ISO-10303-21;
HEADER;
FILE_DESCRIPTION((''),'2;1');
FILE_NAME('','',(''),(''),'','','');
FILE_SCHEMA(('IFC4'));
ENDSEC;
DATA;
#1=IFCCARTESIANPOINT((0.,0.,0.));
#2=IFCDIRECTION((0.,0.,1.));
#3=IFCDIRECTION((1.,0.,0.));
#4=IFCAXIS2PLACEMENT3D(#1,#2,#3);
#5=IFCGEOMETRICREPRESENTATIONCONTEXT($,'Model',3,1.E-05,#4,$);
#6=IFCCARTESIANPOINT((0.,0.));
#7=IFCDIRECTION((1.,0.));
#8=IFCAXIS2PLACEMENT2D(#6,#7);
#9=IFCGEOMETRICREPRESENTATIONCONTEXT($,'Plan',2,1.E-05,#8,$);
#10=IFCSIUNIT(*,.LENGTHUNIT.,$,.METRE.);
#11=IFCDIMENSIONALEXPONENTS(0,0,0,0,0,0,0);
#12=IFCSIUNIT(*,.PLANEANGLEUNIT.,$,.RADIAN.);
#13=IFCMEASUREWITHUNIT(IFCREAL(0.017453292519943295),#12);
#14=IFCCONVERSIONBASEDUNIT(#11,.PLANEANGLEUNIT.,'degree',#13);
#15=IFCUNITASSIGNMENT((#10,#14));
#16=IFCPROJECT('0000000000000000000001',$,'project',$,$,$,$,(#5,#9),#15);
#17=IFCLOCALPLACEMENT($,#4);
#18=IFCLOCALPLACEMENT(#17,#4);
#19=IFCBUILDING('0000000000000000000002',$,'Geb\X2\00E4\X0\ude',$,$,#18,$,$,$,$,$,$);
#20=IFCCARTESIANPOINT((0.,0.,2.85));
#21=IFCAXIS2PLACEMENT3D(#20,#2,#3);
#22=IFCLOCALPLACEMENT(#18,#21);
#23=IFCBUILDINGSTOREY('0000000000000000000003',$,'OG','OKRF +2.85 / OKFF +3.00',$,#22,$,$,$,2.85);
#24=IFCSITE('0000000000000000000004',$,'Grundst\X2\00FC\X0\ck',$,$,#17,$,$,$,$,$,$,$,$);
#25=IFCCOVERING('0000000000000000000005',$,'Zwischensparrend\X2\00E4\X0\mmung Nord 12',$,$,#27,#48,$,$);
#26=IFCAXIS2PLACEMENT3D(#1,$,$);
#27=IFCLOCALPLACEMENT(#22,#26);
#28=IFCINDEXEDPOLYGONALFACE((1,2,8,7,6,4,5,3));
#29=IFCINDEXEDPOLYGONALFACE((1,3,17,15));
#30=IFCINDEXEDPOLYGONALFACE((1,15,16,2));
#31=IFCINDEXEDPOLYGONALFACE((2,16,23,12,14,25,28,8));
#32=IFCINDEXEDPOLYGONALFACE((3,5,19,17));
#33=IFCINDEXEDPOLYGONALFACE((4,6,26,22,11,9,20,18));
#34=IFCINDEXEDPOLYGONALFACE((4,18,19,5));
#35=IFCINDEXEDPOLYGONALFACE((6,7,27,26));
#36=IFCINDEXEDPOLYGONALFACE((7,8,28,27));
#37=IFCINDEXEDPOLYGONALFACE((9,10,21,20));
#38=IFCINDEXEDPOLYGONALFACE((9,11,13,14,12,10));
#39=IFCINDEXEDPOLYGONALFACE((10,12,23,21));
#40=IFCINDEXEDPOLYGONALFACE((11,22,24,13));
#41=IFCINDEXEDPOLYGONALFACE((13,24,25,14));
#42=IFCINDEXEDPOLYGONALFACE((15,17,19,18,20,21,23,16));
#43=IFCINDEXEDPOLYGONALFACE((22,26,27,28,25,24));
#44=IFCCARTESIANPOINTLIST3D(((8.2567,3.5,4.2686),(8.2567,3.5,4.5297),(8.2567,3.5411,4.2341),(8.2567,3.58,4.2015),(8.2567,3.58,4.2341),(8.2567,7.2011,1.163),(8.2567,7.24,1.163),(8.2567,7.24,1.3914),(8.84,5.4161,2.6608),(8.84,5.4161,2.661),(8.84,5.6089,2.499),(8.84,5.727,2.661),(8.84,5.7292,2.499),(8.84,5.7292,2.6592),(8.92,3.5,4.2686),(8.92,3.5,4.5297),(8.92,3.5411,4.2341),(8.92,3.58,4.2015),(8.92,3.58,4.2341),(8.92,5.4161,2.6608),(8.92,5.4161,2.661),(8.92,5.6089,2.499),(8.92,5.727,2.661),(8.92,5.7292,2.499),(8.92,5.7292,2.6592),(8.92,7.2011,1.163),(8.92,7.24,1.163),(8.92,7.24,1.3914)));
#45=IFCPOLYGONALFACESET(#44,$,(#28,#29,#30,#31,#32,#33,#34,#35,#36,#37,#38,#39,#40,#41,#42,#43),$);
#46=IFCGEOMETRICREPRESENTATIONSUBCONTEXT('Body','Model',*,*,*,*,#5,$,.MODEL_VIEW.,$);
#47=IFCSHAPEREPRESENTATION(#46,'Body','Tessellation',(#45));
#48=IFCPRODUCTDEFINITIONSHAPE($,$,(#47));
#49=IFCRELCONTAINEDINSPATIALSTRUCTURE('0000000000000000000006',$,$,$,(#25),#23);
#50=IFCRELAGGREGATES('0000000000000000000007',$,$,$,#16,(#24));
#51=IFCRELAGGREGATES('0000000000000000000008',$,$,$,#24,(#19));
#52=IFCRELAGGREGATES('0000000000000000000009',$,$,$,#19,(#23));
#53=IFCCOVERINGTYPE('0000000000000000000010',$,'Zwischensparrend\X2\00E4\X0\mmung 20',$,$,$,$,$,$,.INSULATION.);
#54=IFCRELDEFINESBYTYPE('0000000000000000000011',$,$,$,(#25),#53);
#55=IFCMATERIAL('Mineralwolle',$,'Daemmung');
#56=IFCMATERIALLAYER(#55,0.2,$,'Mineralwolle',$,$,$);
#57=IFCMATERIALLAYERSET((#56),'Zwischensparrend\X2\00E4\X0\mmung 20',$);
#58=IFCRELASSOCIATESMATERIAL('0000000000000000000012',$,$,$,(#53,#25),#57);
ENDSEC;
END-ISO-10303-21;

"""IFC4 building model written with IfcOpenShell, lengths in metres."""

from ifc_helpers import new_model, entity, si_unit, converted_unit, frame, origin_with_axes, origin_2d_with_axis, place, context, subcontext, project, spatial, polyline, outline, extrude, material, layer, layer_set, layer_usage, type_object, element, save


model = new_model("IFC4")

# Units and contexts
model_context = context("Model", 3, precision=1e-05, world=origin_with_axes())
plan_context = context("Plan", 2, precision=1e-05, world=origin_2d_with_axis())
body_context = subcontext(model_context, "Body", "Model", "MODEL_VIEW")
ifc_project = project(units=[si_unit("LENGTHUNIT", "METRE"), converted_unit("PLANEANGLEUNIT", "degree", entity("IfcReal", 0.017453292519943295), si_unit("PLANEANGLEUNIT", "RADIAN"), dimensions=[0, 0, 0, 0, 0, 0, 0])], contexts=[model_context, plan_context])

# Site, building, storey
site_placement = place(None, origin_with_axes())
site = spatial("IfcSite", under=ifc_project, at=site_placement, Name="Grundstück")
building_placement = place(site_placement, origin_with_axes())
building = spatial("IfcBuilding", under=site, at=building_placement, Name="Gebäude")
storey_placement = place(building_placement, frame((0.0, 0.0, 2.85), z_axis=(0.0, 0.0, 1.0), x_axis=(1.0, 0.0, 0.0)))
storey = spatial("IfcBuildingStorey", under=building, at=storey_placement, Name="OG", Description="OKRF +2.85 / OKFF +3.00", Elevation=2.85)

# Shared definitions
ifc_material_1 = material(Name="Mineralwolle", Category="Daemmung")
ifc_layer_1 = layer(ifc_material_1, 0.2, Name="Mineralwolle")
ifc_layer_set_1 = layer_set([ifc_layer_1], Name="Zwischensparrendämmung 20")
covering_type_1 = type_object("IfcCoveringType", Name="Zwischensparrendämmung 20", PredefinedType="INSULATION", material=ifc_layer_set_1)

# Covering, opening
ifc_layer_usage_1 = layer_usage(ifc_layer_set_1, "AXIS3", "POSITIVE", 0.0)
covering_1_placement = place(storey_placement, frame((8.92, 7.24, 1.1304), z_axis=(0.0, 0.642788, 0.766044), x_axis=(-1.0, 0.0, 0.0)))
covering_1 = element("IfcCovering", 1, at=covering_1_placement, inside=storey, type_object=covering_type_1, material=ifc_layer_usage_1, Name="Zwischensparrendämmung Nord 12", context=body_context, shape_type="SweptSolid", body=[
    extrude(outline(polyline([(0.021, 0.025), (0.0508, 0.0), (4.7778, 0.0), (4.7988, 0.025), (4.8286, 0.0), (4.8822, 0.0), (5.05, 0.2), (0.1678, 0.2), (0.021, 0.025)])), frame((0.0, 0.0, 0.0), z_axis=(1.0, 0.0, 0.0), x_axis=(0.0, 1.0, 0.0)), (0.0, 0.0, 1.0), 0.6633),
])
opening_1_placement = place(covering_1_placement, frame((8.92, 2.9876, -7.7029), z_axis=(0.0, 0.642788, 0.766044), x_axis=(-1.0, 0.0, 0.0)))
element("IfcOpeningElement", 2, at=opening_1_placement, cuts=covering_1, PredefinedType="RECESS", context=body_context, shape_type="SweptSolid", body=[
    extrude(outline(polyline([(8.84, 5.4161), (8.92, 5.4161), (8.92, 5.7292), (8.84, 5.7292), (8.84, 5.4161)])), frame((0.0, 0.0, 5.349), z_axis=(0.0, 0.0, 1.0), x_axis=(1.0, 0.0, 0.0)), (0.0, 0.0, 1.0), 0.162),
])

save(model, "model.ifc")
